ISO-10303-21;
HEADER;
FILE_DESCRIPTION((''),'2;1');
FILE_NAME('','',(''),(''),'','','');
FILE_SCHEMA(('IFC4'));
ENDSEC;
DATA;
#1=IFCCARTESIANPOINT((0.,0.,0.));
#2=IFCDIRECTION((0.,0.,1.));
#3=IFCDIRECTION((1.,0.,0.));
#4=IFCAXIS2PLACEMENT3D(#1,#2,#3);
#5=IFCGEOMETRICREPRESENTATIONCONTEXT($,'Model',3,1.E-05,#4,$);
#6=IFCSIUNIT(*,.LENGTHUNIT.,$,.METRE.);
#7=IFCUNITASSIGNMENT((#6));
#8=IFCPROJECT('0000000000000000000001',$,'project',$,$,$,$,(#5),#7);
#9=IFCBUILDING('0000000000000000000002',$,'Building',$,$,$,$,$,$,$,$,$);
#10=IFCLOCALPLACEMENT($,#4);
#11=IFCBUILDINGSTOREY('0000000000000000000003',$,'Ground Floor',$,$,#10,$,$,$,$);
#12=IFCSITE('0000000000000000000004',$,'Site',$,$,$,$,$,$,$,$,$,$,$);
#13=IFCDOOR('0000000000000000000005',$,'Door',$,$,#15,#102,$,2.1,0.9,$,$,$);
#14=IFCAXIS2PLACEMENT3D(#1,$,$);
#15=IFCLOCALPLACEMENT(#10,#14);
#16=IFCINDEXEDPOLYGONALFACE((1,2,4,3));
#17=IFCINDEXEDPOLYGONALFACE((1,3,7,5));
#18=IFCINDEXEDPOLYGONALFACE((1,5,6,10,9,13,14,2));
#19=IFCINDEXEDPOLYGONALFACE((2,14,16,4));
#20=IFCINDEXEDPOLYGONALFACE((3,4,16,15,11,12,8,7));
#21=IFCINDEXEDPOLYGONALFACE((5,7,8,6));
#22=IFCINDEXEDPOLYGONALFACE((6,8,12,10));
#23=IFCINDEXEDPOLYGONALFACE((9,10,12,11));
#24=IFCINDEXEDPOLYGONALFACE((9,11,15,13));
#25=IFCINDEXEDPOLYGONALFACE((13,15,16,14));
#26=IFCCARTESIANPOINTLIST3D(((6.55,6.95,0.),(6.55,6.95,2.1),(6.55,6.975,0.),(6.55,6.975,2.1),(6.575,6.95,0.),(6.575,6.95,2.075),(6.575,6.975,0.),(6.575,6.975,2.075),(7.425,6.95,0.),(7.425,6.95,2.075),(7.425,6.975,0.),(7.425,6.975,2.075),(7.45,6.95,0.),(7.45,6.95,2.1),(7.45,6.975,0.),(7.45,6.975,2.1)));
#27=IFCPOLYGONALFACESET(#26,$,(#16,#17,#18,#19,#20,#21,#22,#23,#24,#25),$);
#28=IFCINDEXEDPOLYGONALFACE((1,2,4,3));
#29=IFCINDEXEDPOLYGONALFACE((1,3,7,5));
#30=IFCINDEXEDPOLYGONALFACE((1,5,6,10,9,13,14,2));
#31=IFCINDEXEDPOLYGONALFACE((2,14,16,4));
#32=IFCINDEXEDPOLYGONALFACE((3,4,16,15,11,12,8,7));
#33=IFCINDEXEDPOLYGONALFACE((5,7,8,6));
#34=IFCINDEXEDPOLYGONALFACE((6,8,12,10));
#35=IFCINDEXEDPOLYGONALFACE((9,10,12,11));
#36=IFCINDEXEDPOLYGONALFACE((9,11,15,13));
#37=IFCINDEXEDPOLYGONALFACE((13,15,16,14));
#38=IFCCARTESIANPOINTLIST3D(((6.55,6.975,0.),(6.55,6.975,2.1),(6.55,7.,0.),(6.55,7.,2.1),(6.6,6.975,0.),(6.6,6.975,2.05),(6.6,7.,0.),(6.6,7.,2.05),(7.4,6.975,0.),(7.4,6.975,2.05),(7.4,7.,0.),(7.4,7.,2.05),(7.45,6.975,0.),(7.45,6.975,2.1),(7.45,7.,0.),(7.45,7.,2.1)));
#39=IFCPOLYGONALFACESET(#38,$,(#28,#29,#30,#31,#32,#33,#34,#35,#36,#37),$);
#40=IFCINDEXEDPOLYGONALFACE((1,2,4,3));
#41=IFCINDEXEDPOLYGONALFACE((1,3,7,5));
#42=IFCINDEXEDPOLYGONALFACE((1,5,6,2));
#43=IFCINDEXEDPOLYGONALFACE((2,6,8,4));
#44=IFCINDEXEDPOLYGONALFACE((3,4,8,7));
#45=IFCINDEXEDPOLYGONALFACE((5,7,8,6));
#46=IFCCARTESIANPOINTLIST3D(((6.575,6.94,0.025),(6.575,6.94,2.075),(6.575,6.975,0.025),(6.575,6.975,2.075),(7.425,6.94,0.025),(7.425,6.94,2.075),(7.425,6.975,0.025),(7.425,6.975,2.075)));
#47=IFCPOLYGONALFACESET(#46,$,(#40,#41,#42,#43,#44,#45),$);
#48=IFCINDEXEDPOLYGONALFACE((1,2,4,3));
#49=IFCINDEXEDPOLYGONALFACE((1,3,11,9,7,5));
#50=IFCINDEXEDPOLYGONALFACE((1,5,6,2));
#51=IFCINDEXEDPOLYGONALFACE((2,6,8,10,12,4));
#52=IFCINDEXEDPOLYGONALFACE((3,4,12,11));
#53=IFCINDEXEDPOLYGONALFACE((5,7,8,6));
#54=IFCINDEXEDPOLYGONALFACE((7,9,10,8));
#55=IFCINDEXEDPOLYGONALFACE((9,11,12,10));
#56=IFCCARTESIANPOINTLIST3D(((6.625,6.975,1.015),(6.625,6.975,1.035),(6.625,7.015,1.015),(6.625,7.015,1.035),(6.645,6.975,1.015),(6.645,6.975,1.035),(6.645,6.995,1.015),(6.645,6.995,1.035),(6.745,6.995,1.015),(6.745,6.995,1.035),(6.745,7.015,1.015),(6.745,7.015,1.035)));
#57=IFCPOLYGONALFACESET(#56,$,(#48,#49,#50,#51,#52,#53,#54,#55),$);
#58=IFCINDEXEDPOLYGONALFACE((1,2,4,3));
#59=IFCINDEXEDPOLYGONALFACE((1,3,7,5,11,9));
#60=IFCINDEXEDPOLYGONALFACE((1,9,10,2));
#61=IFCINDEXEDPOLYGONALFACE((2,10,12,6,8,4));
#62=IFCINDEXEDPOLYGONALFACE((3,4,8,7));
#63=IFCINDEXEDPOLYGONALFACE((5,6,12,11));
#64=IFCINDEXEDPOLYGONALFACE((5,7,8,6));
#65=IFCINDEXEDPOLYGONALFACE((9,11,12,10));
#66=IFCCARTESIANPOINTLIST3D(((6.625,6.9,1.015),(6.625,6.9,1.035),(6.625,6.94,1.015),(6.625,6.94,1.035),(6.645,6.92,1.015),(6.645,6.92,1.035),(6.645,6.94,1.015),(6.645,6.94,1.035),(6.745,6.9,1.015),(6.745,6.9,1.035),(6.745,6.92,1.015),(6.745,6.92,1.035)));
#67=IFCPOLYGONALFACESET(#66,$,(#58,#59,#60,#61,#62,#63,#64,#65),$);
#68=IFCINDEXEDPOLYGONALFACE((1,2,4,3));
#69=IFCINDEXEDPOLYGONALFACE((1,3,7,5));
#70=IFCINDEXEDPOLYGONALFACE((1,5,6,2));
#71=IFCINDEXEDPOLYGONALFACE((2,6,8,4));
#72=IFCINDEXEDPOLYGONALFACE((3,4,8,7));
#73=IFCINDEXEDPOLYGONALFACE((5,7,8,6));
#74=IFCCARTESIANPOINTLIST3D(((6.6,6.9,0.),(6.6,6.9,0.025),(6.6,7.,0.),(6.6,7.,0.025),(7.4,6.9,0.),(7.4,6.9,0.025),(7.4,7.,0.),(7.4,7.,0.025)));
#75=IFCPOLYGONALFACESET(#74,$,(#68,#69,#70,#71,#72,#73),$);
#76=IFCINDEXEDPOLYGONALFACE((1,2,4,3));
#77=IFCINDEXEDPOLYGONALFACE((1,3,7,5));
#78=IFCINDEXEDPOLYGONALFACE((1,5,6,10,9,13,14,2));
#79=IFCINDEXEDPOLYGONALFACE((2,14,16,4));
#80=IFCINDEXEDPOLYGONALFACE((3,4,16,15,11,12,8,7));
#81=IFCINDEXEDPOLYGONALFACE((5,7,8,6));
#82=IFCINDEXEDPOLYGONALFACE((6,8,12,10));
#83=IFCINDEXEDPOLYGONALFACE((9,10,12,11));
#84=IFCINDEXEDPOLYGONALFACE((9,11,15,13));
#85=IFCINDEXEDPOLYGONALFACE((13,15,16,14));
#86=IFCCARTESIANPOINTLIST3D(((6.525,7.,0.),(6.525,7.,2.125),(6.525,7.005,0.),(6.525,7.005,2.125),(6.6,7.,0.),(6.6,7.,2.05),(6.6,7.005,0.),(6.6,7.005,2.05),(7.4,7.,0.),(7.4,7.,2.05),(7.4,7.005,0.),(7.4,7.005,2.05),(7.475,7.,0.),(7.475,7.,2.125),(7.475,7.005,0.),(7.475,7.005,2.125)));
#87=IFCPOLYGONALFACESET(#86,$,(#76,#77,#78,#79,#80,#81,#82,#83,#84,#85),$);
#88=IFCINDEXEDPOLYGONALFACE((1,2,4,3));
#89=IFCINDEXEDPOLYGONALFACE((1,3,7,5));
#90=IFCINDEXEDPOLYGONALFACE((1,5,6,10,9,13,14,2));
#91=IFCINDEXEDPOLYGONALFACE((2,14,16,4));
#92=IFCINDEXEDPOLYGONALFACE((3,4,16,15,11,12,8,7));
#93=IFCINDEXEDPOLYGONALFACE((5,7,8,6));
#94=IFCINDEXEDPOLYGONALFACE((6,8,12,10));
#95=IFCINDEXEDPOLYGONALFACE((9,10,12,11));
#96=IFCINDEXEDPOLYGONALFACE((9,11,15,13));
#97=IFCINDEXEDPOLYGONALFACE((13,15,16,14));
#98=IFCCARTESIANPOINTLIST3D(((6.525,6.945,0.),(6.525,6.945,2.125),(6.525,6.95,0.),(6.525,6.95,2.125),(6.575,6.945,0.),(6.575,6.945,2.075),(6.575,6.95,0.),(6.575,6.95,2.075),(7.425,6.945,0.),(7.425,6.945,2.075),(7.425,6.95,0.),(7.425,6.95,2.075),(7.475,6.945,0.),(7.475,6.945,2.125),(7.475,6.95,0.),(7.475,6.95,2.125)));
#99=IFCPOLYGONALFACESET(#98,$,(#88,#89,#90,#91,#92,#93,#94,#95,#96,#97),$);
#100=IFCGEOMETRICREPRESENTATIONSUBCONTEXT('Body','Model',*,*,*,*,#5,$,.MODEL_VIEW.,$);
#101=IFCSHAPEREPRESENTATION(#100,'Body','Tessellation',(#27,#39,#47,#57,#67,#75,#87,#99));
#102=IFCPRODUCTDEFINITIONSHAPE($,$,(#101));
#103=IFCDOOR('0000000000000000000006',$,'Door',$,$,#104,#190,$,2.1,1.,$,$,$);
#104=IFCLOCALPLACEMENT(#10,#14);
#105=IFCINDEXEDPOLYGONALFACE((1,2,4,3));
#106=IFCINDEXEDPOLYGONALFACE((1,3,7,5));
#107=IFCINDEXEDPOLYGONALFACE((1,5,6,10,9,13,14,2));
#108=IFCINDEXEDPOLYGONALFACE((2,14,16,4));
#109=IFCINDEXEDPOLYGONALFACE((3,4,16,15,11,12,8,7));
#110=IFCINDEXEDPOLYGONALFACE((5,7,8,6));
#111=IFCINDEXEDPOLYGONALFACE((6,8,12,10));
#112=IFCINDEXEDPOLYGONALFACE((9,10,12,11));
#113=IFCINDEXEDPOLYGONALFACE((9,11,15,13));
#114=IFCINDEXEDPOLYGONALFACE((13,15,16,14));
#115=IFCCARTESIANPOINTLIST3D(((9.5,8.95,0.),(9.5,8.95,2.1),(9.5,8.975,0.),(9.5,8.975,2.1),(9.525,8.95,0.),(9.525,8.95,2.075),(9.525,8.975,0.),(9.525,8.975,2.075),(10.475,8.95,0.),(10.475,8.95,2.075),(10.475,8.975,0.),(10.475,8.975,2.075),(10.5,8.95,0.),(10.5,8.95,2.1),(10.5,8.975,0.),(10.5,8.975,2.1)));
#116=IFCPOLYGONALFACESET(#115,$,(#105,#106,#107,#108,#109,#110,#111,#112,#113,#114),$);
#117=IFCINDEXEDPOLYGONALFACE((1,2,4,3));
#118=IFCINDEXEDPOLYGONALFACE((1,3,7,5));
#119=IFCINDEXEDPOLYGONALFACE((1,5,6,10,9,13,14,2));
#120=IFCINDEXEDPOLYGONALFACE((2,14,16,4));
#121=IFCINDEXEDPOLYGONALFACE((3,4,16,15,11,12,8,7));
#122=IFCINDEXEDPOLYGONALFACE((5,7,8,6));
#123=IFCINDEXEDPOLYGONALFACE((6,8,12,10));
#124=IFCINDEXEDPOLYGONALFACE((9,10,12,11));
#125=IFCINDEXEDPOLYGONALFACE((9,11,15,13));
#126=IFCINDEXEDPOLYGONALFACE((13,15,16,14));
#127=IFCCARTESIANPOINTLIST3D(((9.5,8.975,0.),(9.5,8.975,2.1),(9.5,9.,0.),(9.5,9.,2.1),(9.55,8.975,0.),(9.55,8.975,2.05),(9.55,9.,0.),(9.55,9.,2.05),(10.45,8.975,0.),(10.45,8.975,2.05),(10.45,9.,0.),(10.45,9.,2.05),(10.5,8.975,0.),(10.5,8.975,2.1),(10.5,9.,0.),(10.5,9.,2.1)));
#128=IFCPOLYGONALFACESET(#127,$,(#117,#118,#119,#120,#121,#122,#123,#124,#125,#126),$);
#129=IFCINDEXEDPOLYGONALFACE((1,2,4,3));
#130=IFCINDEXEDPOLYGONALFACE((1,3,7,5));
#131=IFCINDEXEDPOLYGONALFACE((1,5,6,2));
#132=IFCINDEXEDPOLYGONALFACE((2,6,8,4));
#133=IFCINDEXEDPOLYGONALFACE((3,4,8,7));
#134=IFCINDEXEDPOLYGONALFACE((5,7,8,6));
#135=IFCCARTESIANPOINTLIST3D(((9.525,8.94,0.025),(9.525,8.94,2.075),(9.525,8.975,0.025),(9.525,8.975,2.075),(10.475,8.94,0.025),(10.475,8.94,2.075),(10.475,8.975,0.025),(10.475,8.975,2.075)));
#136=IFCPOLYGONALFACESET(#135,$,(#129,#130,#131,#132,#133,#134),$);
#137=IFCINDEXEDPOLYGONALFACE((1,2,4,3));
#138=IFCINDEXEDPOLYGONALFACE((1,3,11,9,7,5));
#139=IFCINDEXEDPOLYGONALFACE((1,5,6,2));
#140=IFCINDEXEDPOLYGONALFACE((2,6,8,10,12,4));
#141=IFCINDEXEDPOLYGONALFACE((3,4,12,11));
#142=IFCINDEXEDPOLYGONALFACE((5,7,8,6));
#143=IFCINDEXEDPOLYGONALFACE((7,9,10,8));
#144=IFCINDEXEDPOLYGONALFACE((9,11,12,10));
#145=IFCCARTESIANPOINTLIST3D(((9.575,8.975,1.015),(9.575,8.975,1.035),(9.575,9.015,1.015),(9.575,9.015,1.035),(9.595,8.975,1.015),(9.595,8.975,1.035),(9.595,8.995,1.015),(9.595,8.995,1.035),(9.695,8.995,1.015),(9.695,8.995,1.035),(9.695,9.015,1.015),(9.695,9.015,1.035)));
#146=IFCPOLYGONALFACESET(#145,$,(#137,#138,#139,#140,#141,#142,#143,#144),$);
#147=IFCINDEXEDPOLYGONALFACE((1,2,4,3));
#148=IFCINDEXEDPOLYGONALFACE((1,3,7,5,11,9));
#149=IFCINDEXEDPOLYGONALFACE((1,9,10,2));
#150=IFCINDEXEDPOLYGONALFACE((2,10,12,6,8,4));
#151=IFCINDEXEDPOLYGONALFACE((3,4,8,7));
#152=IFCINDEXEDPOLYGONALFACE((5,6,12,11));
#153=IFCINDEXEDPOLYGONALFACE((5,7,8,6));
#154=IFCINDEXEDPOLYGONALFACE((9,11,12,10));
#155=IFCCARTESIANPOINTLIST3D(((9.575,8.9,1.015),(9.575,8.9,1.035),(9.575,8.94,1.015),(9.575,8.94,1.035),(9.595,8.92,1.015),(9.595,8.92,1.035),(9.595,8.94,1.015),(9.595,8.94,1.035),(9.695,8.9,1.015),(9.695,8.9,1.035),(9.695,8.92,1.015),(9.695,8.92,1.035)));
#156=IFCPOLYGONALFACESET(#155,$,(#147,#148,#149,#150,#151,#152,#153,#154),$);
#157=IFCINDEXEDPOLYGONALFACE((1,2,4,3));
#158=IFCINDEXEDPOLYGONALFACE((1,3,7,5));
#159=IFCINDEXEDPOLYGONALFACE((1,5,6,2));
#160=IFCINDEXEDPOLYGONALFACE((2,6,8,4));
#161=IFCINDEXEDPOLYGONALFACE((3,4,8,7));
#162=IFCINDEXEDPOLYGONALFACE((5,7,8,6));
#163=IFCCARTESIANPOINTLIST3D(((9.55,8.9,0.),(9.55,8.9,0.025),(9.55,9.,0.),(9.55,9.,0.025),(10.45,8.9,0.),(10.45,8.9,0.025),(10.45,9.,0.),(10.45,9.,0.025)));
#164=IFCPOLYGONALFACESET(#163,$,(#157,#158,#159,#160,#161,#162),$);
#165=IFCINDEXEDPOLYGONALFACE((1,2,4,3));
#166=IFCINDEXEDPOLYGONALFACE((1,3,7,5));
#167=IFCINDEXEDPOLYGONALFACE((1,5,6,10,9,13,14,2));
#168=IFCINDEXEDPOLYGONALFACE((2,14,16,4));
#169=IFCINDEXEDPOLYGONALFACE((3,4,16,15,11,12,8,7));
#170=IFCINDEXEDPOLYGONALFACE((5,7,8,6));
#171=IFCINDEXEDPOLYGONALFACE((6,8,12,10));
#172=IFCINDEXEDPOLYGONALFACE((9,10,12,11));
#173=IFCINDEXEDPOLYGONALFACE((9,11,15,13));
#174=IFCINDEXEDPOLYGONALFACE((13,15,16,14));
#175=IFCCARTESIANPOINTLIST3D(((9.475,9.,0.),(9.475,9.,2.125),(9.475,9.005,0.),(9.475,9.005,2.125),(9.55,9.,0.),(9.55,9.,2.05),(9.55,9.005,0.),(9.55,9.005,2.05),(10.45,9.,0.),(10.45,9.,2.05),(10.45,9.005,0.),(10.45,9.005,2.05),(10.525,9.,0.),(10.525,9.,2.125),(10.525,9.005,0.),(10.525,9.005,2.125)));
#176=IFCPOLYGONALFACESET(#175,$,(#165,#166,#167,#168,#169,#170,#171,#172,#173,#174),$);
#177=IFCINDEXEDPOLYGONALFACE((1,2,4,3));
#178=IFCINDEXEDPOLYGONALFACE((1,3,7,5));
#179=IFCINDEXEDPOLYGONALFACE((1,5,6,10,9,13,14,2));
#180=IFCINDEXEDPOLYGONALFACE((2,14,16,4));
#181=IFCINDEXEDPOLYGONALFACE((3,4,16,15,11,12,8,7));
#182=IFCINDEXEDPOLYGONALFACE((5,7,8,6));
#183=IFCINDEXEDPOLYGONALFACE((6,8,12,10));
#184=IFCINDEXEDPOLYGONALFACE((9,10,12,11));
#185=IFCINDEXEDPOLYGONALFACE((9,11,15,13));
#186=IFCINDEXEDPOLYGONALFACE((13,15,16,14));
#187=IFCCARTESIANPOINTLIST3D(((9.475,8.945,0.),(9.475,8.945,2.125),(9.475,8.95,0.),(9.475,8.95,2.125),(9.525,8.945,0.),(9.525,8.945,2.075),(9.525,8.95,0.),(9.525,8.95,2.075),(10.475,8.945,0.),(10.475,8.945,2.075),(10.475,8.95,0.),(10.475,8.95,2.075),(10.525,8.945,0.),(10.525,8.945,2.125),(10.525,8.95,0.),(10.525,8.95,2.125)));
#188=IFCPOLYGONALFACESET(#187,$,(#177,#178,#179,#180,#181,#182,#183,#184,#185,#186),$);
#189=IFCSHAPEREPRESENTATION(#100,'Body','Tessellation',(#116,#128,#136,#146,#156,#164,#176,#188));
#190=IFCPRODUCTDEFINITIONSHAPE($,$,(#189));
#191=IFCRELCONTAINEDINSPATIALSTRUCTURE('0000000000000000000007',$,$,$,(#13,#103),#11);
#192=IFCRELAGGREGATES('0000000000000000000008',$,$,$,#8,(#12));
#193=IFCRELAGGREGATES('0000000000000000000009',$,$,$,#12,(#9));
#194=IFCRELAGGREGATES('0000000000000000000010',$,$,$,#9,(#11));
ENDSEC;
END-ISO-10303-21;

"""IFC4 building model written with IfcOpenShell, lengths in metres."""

from ifc_helpers import new_model, si_unit, frame, origin_with_axes, place, context, subcontext, project, spatial, line, indexed_curve, outline, extrude, element, save


model = new_model("IFC4")

# Units and contexts
model_context = context("Model", 3, precision=1e-05, world=origin_with_axes())
body_context = subcontext(model_context, "Body", "Model", "MODEL_VIEW")
ifc_project = project(units=[si_unit("LENGTHUNIT", "METRE")], contexts=[model_context])

# Site, building, storey
site = spatial("IfcSite", under=ifc_project, Name="Site")
building = spatial("IfcBuilding", under=site, Name="Building")
storey_placement = place(None, origin_with_axes())
storey = spatial("IfcBuildingStorey", under=building, at=storey_placement, Name="Ground Floor")

# Doors
door_1_placement = place(storey_placement, frame((7.45, 7.0, 0.0), z_axis=(0.0, 0.0, 1.0), x_axis=(-1.0, 0.0, 0.0)))
element("IfcDoor", 1, at=door_1_placement, inside=storey, Name="Door", OverallHeight=2.1, OverallWidth=0.9, context=body_context, shape_type="SweptSolid", body=[
    extrude(outline(indexed_curve([(0.0, 0.0), (0.0, 2.1), (0.9, 2.1), (0.9, 0.0), (0.875, 0.0), (0.875, 2.075), (0.025, 2.075), (0.025, 0.0)], segments=[line(1, 2, 3, 4, 5, 6, 7, 8, 1)])), frame((0.0, 0.025, 0.0), z_axis=(0.0, -1.0, 0.0), x_axis=(1.0, 0.0, 0.0)), (0.0, 0.0, -1.0), 0.025),
    extrude(outline(indexed_curve([(0.0, 0.0), (0.0, 2.1), (0.9, 2.1), (0.9, 0.0), (0.85, 0.0), (0.85, 2.05), (0.05, 2.05), (0.05, 0.0)], segments=[line(1, 2, 3, 4, 5, 6, 7, 8, 1)])), frame((0.0, 0.0, 0.0), z_axis=(0.0, -1.0, 0.0), x_axis=(1.0, 0.0, 0.0)), (0.0, 0.0, -1.0), 0.025),
    extrude(outline(indexed_curve([(0.0, 0.0), (0.85, 0.0), (0.85, 0.035), (0.0, 0.035)], segments=[line(1, 2, 3, 4, 1)])), frame((0.025, 0.025, 0.025), z_axis=(0.0, 0.0, 1.0), x_axis=(1.0, 0.0, 0.0)), (0.0, 0.0, 1.0), 2.05),
    extrude(outline(indexed_curve([(0.0, 0.0), (0.0, -0.04), (-0.12, -0.04), (-0.12, -0.02), (-0.02, -0.02), (-0.02, 0.0)], segments=[line(1, 2, 3, 4, 5, 6, 1)])), frame((0.825, 0.025, 1.015), z_axis=(0.0, 0.0, 1.0), x_axis=(1.0, 0.0, 0.0)), (0.0, 0.0, 1.0), 0.02),
    extrude(outline(indexed_curve([(0.0, 0.0), (0.0, 0.04), (-0.12, 0.04), (-0.12, 0.02), (-0.02, 0.02), (-0.02, 0.0)], segments=[line(1, 2, 3, 4, 5, 6, 1)])), frame((0.825, 0.06, 1.015), z_axis=(0.0, 0.0, 1.0), x_axis=(1.0, 0.0, 0.0)), (0.0, 0.0, 1.0), 0.02),
    extrude(outline(indexed_curve([(0.0, 0.0), (0.8, 0.0), (0.8, 0.1), (0.0, 0.1)], segments=[line(1, 2, 3, 4, 1)])), frame((0.05, 0.0, 0.0), z_axis=(0.0, 0.0, 1.0), x_axis=(1.0, 0.0, 0.0)), (0.0, 0.0, 1.0), 0.025),
    extrude(outline(indexed_curve([(0.0, 0.0), (0.0, 2.125), (0.95, 2.125), (0.95, 0.0), (0.875, 0.0), (0.875, 2.05), (0.075, 2.05), (0.075, 0.0)], segments=[line(1, 2, 3, 4, 5, 6, 7, 8, 1)])), frame((-0.025, -0.005, 0.0), z_axis=(0.0, -1.0, 0.0), x_axis=(1.0, 0.0, 0.0)), (0.0, 0.0, -1.0), 0.005),
    extrude(outline(indexed_curve([(0.0, 0.0), (0.0, 2.125), (0.95, 2.125), (0.95, 0.0), (0.9, 0.0), (0.9, 2.075), (0.05, 2.075), (0.05, 0.0)], segments=[line(1, 2, 3, 4, 5, 6, 7, 8, 1)])), frame((-0.025, 0.05, 0.0), z_axis=(0.0, -1.0, 0.0), x_axis=(1.0, 0.0, 0.0)), (0.0, 0.0, -1.0), 0.005),
])
door_2_placement = place(storey_placement, frame((10.5, 9.0, 0.0), z_axis=(0.0, 0.0, 1.0), x_axis=(-1.0, 0.0, 0.0)))
element("IfcDoor", 2, at=door_2_placement, inside=storey, Name="Door", OverallHeight=2.1, OverallWidth=1.0, context=body_context, shape_type="SweptSolid", body=[
    extrude(outline(indexed_curve([(0.0, 0.0), (0.0, 2.1), (1.0, 2.1), (1.0, 0.0), (0.975, 0.0), (0.975, 2.075), (0.025, 2.075), (0.025, 0.0)], segments=[line(1, 2, 3, 4, 5, 6, 7, 8, 1)])), frame((0.0, 0.025, 0.0), z_axis=(0.0, -1.0, 0.0), x_axis=(1.0, 0.0, 0.0)), (0.0, 0.0, -1.0), 0.025),
    extrude(outline(indexed_curve([(0.0, 0.0), (0.0, 2.1), (1.0, 2.1), (1.0, 0.0), (0.95, 0.0), (0.95, 2.05), (0.05, 2.05), (0.05, 0.0)], segments=[line(1, 2, 3, 4, 5, 6, 7, 8, 1)])), frame((0.0, 0.0, 0.0), z_axis=(0.0, -1.0, 0.0), x_axis=(1.0, 0.0, 0.0)), (0.0, 0.0, -1.0), 0.025),
    extrude(outline(indexed_curve([(0.0, 0.0), (0.95, 0.0), (0.95, 0.035), (0.0, 0.035)], segments=[line(1, 2, 3, 4, 1)])), frame((0.025, 0.025, 0.025), z_axis=(0.0, 0.0, 1.0), x_axis=(1.0, 0.0, 0.0)), (0.0, 0.0, 1.0), 2.05),
    extrude(outline(indexed_curve([(0.0, 0.0), (0.0, -0.04), (-0.12, -0.04), (-0.12, -0.02), (-0.02, -0.02), (-0.02, 0.0)], segments=[line(1, 2, 3, 4, 5, 6, 1)])), frame((0.925, 0.025, 1.015), z_axis=(0.0, 0.0, 1.0), x_axis=(1.0, 0.0, 0.0)), (0.0, 0.0, 1.0), 0.02),
    extrude(outline(indexed_curve([(0.0, 0.0), (0.0, 0.04), (-0.12, 0.04), (-0.12, 0.02), (-0.02, 0.02), (-0.02, 0.0)], segments=[line(1, 2, 3, 4, 5, 6, 1)])), frame((0.925, 0.06, 1.015), z_axis=(0.0, 0.0, 1.0), x_axis=(1.0, 0.0, 0.0)), (0.0, 0.0, 1.0), 0.02),
    extrude(outline(indexed_curve([(0.0, 0.0), (0.9, 0.0), (0.9, 0.1), (0.0, 0.1)], segments=[line(1, 2, 3, 4, 1)])), frame((0.05, 0.0, 0.0), z_axis=(0.0, 0.0, 1.0), x_axis=(1.0, 0.0, 0.0)), (0.0, 0.0, 1.0), 0.025),
    extrude(outline(indexed_curve([(0.0, 0.0), (0.0, 2.125), (1.05, 2.125), (1.05, 0.0), (0.975, 0.0), (0.975, 2.05), (0.075, 2.05), (0.075, 0.0)], segments=[line(1, 2, 3, 4, 5, 6, 7, 8, 1)])), frame((-0.025, -0.005, 0.0), z_axis=(0.0, -1.0, 0.0), x_axis=(1.0, 0.0, 0.0)), (0.0, 0.0, -1.0), 0.005),
    extrude(outline(indexed_curve([(0.0, 0.0), (0.0, 2.125), (1.05, 2.125), (1.05, 0.0), (1.0, 0.0), (1.0, 2.075), (0.05, 2.075), (0.05, 0.0)], segments=[line(1, 2, 3, 4, 5, 6, 7, 8, 1)])), frame((-0.025, 0.05, 0.0), z_axis=(0.0, -1.0, 0.0), x_axis=(1.0, 0.0, 0.0)), (0.0, 0.0, -1.0), 0.005),
])

save(model, "model.ifc")
